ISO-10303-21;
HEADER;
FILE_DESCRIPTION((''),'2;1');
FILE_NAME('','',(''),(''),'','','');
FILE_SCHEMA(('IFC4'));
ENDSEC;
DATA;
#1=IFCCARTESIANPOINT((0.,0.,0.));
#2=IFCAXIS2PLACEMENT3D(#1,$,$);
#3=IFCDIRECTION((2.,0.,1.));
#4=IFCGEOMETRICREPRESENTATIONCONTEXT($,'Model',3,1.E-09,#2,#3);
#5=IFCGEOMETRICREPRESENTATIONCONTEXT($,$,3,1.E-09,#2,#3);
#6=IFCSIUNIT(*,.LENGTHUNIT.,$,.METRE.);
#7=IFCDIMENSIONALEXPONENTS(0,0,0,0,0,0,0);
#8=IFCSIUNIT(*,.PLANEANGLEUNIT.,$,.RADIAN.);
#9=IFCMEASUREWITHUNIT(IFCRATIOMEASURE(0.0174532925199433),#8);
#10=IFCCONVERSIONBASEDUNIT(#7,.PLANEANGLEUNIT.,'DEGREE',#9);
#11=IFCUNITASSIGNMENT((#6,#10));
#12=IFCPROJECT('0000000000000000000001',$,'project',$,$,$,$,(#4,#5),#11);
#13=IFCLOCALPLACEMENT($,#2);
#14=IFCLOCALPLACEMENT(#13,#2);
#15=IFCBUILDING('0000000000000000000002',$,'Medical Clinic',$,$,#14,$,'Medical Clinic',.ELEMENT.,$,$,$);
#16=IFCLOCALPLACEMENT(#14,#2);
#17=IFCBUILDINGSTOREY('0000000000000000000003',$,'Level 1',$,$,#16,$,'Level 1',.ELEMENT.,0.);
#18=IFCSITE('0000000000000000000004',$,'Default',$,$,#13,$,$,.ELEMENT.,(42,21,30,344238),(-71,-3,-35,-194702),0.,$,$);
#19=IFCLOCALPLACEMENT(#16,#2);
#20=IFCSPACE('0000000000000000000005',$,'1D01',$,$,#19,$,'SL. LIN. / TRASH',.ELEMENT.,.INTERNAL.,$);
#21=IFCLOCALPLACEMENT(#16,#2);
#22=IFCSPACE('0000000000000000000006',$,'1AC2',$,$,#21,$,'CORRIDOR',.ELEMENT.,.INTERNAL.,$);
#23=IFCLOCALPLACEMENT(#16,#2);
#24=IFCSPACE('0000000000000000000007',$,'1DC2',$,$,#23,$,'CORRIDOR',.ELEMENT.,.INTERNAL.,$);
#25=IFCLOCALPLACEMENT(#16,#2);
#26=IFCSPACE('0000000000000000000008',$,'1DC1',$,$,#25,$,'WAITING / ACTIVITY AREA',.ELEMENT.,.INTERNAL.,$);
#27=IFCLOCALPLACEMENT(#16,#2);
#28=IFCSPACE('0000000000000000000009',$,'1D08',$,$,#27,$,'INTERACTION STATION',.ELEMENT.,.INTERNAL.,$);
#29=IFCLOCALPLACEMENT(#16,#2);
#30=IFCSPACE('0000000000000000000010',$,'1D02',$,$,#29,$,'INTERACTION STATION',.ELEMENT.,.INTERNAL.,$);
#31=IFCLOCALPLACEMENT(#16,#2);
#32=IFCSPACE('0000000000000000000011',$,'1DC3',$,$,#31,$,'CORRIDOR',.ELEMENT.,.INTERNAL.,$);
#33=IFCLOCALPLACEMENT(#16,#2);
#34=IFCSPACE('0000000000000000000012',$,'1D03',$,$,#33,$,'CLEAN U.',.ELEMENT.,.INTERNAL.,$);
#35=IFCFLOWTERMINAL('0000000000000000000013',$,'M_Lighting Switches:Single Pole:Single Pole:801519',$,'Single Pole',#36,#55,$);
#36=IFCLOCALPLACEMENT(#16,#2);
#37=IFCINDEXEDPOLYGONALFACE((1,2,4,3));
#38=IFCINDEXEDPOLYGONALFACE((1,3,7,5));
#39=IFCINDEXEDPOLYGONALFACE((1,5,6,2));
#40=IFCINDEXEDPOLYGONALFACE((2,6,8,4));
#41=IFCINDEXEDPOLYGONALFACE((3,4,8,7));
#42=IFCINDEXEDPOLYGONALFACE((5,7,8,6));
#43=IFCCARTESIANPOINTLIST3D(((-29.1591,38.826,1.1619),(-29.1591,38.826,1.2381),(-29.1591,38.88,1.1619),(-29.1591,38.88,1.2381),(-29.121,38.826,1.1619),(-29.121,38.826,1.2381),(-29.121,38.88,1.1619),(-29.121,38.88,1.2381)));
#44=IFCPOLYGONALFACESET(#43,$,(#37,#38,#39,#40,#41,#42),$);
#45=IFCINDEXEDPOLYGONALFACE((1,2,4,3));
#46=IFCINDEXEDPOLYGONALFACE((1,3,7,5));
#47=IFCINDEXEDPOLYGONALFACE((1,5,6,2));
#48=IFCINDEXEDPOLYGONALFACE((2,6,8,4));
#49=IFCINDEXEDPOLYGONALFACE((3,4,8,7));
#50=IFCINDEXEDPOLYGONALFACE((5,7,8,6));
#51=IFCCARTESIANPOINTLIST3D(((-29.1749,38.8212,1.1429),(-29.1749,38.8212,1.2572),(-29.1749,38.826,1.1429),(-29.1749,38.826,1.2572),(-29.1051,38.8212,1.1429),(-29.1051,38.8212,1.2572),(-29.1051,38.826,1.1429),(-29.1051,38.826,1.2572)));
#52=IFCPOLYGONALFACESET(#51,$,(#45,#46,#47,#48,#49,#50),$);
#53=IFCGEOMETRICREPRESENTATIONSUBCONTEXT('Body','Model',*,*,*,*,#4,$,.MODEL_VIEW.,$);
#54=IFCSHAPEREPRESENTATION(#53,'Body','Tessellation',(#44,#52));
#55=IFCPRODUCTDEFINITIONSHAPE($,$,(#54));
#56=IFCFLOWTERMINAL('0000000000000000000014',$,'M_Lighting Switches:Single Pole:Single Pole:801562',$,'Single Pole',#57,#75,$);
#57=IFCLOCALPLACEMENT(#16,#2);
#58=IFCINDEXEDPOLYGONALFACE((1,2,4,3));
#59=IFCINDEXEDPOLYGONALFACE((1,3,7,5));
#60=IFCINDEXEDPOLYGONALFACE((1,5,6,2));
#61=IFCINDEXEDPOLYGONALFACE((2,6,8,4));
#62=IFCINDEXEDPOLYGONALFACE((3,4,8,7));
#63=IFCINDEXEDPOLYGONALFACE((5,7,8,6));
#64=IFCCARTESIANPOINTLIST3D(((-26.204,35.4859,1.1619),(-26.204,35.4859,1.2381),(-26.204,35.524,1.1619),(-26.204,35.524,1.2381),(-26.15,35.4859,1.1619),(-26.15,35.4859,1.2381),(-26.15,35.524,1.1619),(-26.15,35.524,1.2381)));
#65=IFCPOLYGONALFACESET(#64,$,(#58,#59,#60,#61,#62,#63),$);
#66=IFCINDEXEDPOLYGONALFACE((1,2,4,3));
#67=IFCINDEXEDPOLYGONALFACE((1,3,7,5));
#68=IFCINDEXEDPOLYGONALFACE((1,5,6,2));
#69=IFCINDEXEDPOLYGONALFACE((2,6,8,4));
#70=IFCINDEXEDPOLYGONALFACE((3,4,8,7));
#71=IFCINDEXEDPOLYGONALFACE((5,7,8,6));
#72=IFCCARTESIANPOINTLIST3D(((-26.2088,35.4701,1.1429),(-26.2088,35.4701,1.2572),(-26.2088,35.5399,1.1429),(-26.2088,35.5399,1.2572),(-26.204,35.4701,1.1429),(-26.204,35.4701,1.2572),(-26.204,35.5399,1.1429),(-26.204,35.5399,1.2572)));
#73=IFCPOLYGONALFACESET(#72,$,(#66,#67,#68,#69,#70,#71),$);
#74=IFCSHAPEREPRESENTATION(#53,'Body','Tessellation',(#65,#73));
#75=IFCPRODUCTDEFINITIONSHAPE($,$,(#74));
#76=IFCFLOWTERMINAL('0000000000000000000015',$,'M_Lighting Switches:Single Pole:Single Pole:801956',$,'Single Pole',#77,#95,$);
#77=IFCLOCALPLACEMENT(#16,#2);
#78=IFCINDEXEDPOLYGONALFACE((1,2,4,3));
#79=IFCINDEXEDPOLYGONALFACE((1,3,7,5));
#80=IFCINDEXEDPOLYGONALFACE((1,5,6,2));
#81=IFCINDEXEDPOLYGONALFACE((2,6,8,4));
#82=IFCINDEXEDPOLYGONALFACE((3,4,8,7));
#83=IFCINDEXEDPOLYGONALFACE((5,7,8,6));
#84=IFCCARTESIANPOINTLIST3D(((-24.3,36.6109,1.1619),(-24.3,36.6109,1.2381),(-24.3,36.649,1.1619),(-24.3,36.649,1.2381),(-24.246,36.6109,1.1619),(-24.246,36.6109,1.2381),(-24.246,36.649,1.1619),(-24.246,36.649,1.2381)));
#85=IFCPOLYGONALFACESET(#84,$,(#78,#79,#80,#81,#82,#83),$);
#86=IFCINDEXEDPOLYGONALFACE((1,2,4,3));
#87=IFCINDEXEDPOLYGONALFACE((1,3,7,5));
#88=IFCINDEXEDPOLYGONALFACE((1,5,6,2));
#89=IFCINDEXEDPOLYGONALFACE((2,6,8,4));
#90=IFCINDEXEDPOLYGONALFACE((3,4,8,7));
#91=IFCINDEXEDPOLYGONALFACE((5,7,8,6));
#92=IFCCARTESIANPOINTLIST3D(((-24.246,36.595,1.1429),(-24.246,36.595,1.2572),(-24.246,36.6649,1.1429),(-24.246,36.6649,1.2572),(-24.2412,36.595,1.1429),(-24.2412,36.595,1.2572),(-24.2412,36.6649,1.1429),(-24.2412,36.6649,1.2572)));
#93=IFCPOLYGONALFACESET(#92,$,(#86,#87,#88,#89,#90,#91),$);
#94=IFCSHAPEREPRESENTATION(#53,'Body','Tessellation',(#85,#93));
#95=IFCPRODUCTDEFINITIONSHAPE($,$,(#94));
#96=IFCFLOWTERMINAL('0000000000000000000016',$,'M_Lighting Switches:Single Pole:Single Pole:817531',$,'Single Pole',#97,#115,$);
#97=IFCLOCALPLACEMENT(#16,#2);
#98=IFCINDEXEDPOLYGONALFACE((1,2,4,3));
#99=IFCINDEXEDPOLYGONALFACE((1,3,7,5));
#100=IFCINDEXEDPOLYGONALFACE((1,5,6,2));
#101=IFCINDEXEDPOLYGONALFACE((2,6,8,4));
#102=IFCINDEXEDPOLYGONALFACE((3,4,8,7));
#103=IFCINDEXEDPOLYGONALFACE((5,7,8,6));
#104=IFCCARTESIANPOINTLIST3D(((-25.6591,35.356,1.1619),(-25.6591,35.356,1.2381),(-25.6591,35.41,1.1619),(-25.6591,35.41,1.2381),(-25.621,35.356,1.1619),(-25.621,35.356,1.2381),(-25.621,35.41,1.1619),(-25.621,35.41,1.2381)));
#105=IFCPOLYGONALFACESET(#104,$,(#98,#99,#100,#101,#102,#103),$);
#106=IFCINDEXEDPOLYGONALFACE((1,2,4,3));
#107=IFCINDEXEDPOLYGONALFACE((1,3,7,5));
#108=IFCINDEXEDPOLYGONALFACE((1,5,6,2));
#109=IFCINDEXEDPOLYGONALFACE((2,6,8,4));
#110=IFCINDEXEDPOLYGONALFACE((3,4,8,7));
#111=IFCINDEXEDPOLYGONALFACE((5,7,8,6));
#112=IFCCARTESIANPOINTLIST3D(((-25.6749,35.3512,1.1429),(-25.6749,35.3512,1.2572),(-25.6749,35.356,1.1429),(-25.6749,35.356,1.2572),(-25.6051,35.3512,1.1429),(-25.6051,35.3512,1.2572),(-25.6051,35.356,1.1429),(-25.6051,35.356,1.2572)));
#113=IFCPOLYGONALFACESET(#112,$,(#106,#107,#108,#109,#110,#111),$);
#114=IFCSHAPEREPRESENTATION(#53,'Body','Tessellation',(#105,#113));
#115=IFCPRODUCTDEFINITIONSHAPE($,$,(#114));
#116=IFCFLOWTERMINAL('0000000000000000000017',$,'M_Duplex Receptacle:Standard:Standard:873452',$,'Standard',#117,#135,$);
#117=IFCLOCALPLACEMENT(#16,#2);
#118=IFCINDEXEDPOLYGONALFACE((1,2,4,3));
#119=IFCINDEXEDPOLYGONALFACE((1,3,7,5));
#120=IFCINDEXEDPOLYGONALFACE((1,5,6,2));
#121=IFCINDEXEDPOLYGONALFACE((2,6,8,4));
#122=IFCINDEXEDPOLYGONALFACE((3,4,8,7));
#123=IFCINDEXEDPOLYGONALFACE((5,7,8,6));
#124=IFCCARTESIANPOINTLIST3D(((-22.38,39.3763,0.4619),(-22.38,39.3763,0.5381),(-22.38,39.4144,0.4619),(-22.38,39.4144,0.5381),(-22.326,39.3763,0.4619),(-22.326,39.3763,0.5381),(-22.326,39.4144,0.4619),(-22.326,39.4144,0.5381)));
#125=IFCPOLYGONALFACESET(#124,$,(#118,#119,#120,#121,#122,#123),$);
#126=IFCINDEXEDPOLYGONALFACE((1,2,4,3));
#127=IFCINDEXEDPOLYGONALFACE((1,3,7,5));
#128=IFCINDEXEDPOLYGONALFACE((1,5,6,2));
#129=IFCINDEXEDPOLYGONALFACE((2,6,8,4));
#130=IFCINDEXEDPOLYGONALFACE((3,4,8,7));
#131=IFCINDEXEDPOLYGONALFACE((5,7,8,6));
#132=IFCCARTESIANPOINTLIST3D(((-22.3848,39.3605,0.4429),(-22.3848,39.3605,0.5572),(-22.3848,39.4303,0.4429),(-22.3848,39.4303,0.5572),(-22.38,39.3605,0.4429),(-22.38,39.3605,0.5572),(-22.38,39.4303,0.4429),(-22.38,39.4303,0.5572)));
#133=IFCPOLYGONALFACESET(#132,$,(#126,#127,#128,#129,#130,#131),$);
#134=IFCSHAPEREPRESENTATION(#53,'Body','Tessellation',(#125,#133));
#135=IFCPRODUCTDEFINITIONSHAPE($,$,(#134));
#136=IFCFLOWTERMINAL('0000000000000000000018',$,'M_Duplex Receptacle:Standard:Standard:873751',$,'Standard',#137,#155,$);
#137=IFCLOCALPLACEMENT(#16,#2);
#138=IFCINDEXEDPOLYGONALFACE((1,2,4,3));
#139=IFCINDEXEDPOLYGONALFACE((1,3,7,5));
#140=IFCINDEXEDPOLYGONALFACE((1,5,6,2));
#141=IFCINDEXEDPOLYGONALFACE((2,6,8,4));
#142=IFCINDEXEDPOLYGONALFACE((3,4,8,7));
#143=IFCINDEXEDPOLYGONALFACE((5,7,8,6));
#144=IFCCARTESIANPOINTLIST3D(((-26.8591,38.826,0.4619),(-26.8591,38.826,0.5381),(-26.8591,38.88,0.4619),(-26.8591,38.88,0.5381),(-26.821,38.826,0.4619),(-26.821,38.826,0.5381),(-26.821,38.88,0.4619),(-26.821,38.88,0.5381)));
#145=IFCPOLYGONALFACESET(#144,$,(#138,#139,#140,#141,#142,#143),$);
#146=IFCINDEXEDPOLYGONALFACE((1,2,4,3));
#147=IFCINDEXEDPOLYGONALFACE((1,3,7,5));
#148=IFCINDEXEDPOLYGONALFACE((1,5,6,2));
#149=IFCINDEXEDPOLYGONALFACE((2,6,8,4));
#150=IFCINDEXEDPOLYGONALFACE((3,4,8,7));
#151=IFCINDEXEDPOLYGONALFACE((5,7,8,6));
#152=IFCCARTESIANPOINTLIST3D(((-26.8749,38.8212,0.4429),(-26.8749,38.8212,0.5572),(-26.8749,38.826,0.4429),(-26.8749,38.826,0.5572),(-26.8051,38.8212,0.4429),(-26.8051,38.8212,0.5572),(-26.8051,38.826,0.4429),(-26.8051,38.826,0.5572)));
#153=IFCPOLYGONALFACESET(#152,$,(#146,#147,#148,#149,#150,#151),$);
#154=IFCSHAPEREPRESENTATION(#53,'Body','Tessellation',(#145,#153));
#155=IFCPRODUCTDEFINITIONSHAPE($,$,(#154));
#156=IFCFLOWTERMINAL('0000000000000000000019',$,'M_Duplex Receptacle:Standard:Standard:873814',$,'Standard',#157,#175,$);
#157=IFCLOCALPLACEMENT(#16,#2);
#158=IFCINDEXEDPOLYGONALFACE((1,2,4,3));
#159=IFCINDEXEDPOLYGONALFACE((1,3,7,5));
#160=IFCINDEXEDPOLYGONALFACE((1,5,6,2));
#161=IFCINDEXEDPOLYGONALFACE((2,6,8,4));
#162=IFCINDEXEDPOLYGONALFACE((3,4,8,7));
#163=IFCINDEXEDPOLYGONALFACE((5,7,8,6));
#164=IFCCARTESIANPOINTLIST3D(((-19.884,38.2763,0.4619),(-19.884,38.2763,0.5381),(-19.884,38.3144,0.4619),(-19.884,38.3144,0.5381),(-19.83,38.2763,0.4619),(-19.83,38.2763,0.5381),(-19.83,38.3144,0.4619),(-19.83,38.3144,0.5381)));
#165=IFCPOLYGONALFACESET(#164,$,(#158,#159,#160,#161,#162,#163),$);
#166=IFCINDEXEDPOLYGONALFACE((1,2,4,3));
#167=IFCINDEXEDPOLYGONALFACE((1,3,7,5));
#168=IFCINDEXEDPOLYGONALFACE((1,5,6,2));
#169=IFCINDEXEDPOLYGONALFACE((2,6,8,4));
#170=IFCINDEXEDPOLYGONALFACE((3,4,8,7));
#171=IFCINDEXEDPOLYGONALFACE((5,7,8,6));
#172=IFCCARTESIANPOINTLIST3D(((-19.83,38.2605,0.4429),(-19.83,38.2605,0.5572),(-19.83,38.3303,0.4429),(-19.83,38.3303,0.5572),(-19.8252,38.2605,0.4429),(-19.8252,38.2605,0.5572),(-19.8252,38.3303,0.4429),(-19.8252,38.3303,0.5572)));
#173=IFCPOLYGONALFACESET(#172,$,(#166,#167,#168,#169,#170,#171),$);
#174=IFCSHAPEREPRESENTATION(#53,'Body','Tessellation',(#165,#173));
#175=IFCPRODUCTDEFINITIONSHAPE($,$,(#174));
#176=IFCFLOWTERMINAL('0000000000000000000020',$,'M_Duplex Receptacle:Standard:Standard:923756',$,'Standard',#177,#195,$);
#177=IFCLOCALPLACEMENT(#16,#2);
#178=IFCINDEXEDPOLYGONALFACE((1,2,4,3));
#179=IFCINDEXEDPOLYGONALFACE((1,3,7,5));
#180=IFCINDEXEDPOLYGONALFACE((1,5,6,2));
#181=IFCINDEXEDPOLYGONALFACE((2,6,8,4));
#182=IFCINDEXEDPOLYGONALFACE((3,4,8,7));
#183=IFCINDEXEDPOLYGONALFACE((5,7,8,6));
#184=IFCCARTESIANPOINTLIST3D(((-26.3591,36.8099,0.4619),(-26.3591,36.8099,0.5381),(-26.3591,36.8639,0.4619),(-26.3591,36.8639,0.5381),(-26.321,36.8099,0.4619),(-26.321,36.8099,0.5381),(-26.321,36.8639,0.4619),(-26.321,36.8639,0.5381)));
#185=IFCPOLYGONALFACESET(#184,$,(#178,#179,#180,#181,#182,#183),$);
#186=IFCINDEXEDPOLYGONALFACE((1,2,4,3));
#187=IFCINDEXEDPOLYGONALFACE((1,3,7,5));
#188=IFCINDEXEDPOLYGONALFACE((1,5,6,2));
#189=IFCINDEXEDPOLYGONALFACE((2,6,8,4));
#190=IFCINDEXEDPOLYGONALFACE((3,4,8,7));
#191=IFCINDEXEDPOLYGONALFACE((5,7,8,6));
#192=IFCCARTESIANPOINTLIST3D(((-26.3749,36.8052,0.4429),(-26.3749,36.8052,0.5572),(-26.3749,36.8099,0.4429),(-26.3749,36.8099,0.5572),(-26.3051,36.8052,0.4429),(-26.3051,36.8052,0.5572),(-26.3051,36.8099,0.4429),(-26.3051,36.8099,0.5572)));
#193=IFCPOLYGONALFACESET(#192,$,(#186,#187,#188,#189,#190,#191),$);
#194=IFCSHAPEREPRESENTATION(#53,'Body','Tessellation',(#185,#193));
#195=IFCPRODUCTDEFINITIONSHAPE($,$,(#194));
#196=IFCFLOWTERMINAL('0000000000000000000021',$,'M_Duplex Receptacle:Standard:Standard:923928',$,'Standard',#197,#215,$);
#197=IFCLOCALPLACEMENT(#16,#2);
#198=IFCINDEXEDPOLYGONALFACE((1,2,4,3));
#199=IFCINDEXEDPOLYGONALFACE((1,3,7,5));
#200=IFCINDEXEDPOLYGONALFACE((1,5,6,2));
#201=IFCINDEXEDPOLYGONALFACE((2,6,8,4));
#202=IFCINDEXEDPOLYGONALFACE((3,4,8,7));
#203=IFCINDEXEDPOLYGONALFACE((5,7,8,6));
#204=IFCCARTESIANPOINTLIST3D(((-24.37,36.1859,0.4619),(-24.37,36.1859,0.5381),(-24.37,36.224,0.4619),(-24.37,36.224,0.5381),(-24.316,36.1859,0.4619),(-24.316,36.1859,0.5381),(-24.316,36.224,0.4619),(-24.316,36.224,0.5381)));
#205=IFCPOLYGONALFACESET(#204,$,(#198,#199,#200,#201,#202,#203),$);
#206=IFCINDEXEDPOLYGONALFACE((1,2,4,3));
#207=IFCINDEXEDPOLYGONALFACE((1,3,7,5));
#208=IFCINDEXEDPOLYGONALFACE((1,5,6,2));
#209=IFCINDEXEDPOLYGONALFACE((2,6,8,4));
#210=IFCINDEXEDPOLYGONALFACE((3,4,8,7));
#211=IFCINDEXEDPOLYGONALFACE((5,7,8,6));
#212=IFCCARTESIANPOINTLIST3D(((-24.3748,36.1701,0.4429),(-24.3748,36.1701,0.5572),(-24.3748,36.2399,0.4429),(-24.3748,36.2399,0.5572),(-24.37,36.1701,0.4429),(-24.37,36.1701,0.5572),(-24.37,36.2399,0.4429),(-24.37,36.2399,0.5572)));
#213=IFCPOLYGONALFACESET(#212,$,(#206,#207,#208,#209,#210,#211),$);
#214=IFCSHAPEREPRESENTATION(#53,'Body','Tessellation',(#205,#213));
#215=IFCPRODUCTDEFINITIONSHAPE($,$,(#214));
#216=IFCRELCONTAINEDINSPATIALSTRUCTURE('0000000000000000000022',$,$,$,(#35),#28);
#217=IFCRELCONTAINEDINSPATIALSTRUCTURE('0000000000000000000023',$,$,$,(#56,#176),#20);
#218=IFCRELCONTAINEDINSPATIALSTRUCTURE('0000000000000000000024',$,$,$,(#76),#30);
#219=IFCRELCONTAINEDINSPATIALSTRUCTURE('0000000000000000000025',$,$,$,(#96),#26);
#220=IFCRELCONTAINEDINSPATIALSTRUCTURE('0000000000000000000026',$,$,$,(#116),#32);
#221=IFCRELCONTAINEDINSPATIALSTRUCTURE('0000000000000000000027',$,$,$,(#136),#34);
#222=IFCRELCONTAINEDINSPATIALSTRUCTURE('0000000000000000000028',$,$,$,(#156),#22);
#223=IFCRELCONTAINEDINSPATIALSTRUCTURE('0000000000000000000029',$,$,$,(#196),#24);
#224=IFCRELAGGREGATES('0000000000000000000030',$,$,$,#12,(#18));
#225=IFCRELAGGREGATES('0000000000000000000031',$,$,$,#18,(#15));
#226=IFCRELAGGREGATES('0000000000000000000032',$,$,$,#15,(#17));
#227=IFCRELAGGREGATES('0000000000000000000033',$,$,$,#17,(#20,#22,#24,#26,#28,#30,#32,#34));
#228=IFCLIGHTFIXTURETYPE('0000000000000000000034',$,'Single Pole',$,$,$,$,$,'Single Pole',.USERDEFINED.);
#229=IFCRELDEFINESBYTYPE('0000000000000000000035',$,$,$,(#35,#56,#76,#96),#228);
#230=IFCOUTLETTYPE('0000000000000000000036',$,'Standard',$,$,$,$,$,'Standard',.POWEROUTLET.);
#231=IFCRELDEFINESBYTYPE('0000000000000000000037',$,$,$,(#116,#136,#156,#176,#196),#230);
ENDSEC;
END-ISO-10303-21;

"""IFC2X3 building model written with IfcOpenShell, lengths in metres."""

from ifc_helpers import new_model, entity, si_unit, converted_unit, direction, frame, frame_2d, origin, origin_2d_with_axis, place, context, subcontext, project, spatial, rectangle, extrude, source, transform, mapped, type_object, type_shapes, element, save


model = new_model("IFC2X3")

# Units and contexts
model_context = context("Model", 3, precision=1e-09, world=origin(), true_north=direction((2.0, 0.0, 1.0)))
context_of_model = context(None, 3, precision=1e-09, world=origin(), true_north=direction((2.0, 0.0, 1.0)))
body_context = subcontext(model_context, "Body", "Model", "MODEL_VIEW")
ifc_project = project(units=[si_unit("LENGTHUNIT", "METRE"), converted_unit("PLANEANGLEUNIT", "DEGREE", entity("IfcRatioMeasure", 0.0174532925199433), si_unit("PLANEANGLEUNIT", "RADIAN"), dimensions=[0, 0, 0, 0, 0, 0, 0])], contexts=[model_context, context_of_model])

# Site, building, storey
site_placement = place(None, origin())
site = spatial("IfcSite", under=ifc_project, at=site_placement, Name="Default", CompositionType="ELEMENT", RefLatitude=(42, 21, 30, 344238), RefLongitude=(-71, -3, -35, -194702), RefElevation=0.0)
building_placement = place(site_placement, origin())
building = spatial("IfcBuilding", under=site, at=building_placement, Name="Medical Clinic", LongName="Medical Clinic", CompositionType="ELEMENT")
storey_placement = place(building_placement, origin())
storey = spatial("IfcBuildingStorey", under=building, at=storey_placement, Name="Level 1", LongName="Level 1", CompositionType="ELEMENT", Elevation=0.0)

# Shared definitions
space_1_placement = place(storey_placement, origin())
space_1 = spatial("IfcSpace", under=storey, at=space_1_placement, Name="1D01", LongName="SL. LIN. / TRASH", CompositionType="ELEMENT", InteriorOrExteriorSpace="INTERNAL")

# Shared definitions
space_2_placement = place(storey_placement, origin())
space_2 = spatial("IfcSpace", under=storey, at=space_2_placement, Name="1AC2", LongName="CORRIDOR", CompositionType="ELEMENT", InteriorOrExteriorSpace="INTERNAL")

# Shared definitions
space_3_placement = place(storey_placement, origin())
space_3 = spatial("IfcSpace", under=storey, at=space_3_placement, Name="1DC2", LongName="CORRIDOR", CompositionType="ELEMENT", InteriorOrExteriorSpace="INTERNAL")

# Shared definitions
space_4_placement = place(storey_placement, origin())
space_4 = spatial("IfcSpace", under=storey, at=space_4_placement, Name="1DC1", LongName="WAITING / ACTIVITY AREA", CompositionType="ELEMENT", InteriorOrExteriorSpace="INTERNAL")

# Shared definitions
space_5_placement = place(storey_placement, origin())
space_5 = spatial("IfcSpace", under=storey, at=space_5_placement, Name="1D08", LongName="INTERACTION STATION", CompositionType="ELEMENT", InteriorOrExteriorSpace="INTERNAL")

# Flow terminals
light_fixture_type_1 = type_object("IfcLightFixtureType", Name="Single Pole", ElementType="Single Pole", PredefinedType="USERDEFINED")
shared_shape_1 = source(origin(), body_context, "Body", "SweptSolid", [
    extrude(rectangle(XDim=0.0381, YDim=0.0762, at=origin_2d_with_axis()), frame((0.0, 0.0, -0.054), z_axis=(0.0, 0.0, 1.0), x_axis=(-1.0, 0.0, 0.0)), (0.0, 0.0, 1.0), 0.054),
    extrude(rectangle(XDim=0.0698, YDim=0.1143, at=frame_2d((0.0, 0.0), x_axis=(1.0, 0.0))), frame((0.0, 0.0, 0.0), z_axis=(0.0, 0.0, 1.0), x_axis=(-1.0, 0.0, 0.0)), (0.0, 0.0, 1.0), 0.0048),
])
type_shapes(light_fixture_type_1, [shared_shape_1])
flow_terminal_1_placement = place(space_5_placement, frame((-29.14, 38.826, 1.2), z_axis=(0.0, -1.0, 0.0), x_axis=(1.0, 0.0, 0.0)))
element("IfcFlowTerminal", 1, at=flow_terminal_1_placement, inside=space_5, type_object=light_fixture_type_1, Name="M_Lighting Switches:Single Pole:Single Pole:801519", ObjectType="Single Pole", context=body_context, shape_type="MappedRepresentation", body=[
    mapped(shared_shape_1, transform((0.0, 0.0, 0.0), scale=1.0)),
])
flow_terminal_2_placement = place(space_1_placement, frame((-26.204, 35.505, 1.2), z_axis=(-1.0, 0.0, 0.0), x_axis=(0.0, -1.0, 0.0)))
element("IfcFlowTerminal", 2, at=flow_terminal_2_placement, inside=space_1, type_object=light_fixture_type_1, Name="M_Lighting Switches:Single Pole:Single Pole:801562", ObjectType="Single Pole", context=body_context, shape_type="MappedRepresentation", body=[
    mapped(shared_shape_1, transform((0.0, 0.0, 0.0), scale=1.0)),
])

# Shared definitions
space_6_placement = place(storey_placement, origin())
space_6 = spatial("IfcSpace", under=storey, at=space_6_placement, Name="1D02", LongName="INTERACTION STATION", CompositionType="ELEMENT", InteriorOrExteriorSpace="INTERNAL")

# Flow terminals
flow_terminal_3_placement = place(space_6_placement, frame((-24.246, 36.6299, 1.2), z_axis=(1.0, 0.0, 0.0), x_axis=(0.0, 1.0, 0.0)))
element("IfcFlowTerminal", 3, at=flow_terminal_3_placement, inside=space_6, type_object=light_fixture_type_1, Name="M_Lighting Switches:Single Pole:Single Pole:801956", ObjectType="Single Pole", context=body_context, shape_type="MappedRepresentation", body=[
    mapped(shared_shape_1, transform((0.0, 0.0, 0.0), scale=1.0)),
])
flow_terminal_4_placement = place(space_4_placement, frame((-25.64, 35.356, 1.2), z_axis=(0.0, -1.0, 0.0), x_axis=(1.0, 0.0, 0.0)))
element("IfcFlowTerminal", 4, at=flow_terminal_4_placement, inside=space_4, type_object=light_fixture_type_1, Name="M_Lighting Switches:Single Pole:Single Pole:817531", ObjectType="Single Pole", context=body_context, shape_type="MappedRepresentation", body=[
    mapped(shared_shape_1, transform((0.0, 0.0, 0.0), scale=1.0)),
])

# Shared definitions
space_7_placement = place(storey_placement, origin())
space_7 = spatial("IfcSpace", under=storey, at=space_7_placement, Name="1DC3", LongName="CORRIDOR", CompositionType="ELEMENT", InteriorOrExteriorSpace="INTERNAL")

# Flow terminal
outlet_type = type_object("IfcOutletType", Name="Standard", ElementType="Standard", PredefinedType="POWEROUTLET")
shared_shape_2 = source(origin(), body_context, "Body", "SweptSolid", [
    extrude(rectangle(XDim=0.0381, YDim=0.0762, at=origin_2d_with_axis()), frame((0.0, 0.0, -0.054), z_axis=(0.0, 0.0, 1.0), x_axis=(-1.0, 0.0, 0.0)), (0.0, 0.0, 1.0), 0.054),
    extrude(rectangle(XDim=0.0698, YDim=0.1143, at=frame_2d((0.0, 0.0), x_axis=(1.0, 0.0))), frame((0.0, 0.0, 0.0), z_axis=(0.0, 0.0, 1.0), x_axis=(-1.0, 0.0, 0.0)), (0.0, 0.0, 1.0), 0.0048),
])
type_shapes(outlet_type, [shared_shape_2])
flow_terminal_5_placement = place(space_7_placement, frame((-22.38, 39.3954, 0.5), z_axis=(-1.0, 0.0, 0.0), x_axis=(0.0, -1.0, 0.0)))
element("IfcFlowTerminal", 5, at=flow_terminal_5_placement, inside=space_7, type_object=outlet_type, Name="M_Duplex Receptacle:Standard:Standard:873452", ObjectType="Standard", context=body_context, shape_type="MappedRepresentation", body=[
    mapped(shared_shape_2, transform((0.0, 0.0, 0.0), scale=1.0)),
])

# Shared definitions
space_8_placement = place(storey_placement, origin())
space_8 = spatial("IfcSpace", under=storey, at=space_8_placement, Name="1D03", LongName="CLEAN U.", CompositionType="ELEMENT", InteriorOrExteriorSpace="INTERNAL")

# Flow terminals
flow_terminal_6_placement = place(space_8_placement, frame((-26.84, 38.826, 0.5), z_axis=(0.0, -1.0, 0.0), x_axis=(1.0, 0.0, 0.0)))
element("IfcFlowTerminal", 6, at=flow_terminal_6_placement, inside=space_8, type_object=outlet_type, Name="M_Duplex Receptacle:Standard:Standard:873751", ObjectType="Standard", context=body_context, shape_type="MappedRepresentation", body=[
    mapped(shared_shape_2, transform((0.0, 0.0, 0.0), scale=1.0)),
])
flow_terminal_7_placement = place(space_2_placement, frame((-19.83, 38.2954, 0.5), z_axis=(1.0, 0.0, 0.0), x_axis=(0.0, 1.0, 0.0)))
element("IfcFlowTerminal", 7, at=flow_terminal_7_placement, inside=space_2, type_object=outlet_type, Name="M_Duplex Receptacle:Standard:Standard:873814", ObjectType="Standard", context=body_context, shape_type="MappedRepresentation", body=[
    mapped(shared_shape_2, transform((0.0, 0.0, 0.0), scale=1.0)),
])
flow_terminal_8_placement = place(space_1_placement, frame((-26.34, 36.8099, 0.5), z_axis=(0.0, -1.0, 0.0), x_axis=(1.0, 0.0, 0.0)))
element("IfcFlowTerminal", 8, at=flow_terminal_8_placement, inside=space_1, type_object=outlet_type, Name="M_Duplex Receptacle:Standard:Standard:923756", ObjectType="Standard", context=body_context, shape_type="MappedRepresentation", body=[
    mapped(shared_shape_2, transform((0.0, 0.0, 0.0), scale=1.0)),
])
flow_terminal_9_placement = place(space_3_placement, frame((-24.37, 36.205, 0.5), z_axis=(-1.0, 0.0, 0.0), x_axis=(0.0, -1.0, 0.0)))
element("IfcFlowTerminal", 9, at=flow_terminal_9_placement, inside=space_3, type_object=outlet_type, Name="M_Duplex Receptacle:Standard:Standard:923928", ObjectType="Standard", context=body_context, shape_type="MappedRepresentation", body=[
    mapped(shared_shape_2, transform((0.0, 0.0, 0.0), scale=1.0)),
])

save(model, "model.ifc")
